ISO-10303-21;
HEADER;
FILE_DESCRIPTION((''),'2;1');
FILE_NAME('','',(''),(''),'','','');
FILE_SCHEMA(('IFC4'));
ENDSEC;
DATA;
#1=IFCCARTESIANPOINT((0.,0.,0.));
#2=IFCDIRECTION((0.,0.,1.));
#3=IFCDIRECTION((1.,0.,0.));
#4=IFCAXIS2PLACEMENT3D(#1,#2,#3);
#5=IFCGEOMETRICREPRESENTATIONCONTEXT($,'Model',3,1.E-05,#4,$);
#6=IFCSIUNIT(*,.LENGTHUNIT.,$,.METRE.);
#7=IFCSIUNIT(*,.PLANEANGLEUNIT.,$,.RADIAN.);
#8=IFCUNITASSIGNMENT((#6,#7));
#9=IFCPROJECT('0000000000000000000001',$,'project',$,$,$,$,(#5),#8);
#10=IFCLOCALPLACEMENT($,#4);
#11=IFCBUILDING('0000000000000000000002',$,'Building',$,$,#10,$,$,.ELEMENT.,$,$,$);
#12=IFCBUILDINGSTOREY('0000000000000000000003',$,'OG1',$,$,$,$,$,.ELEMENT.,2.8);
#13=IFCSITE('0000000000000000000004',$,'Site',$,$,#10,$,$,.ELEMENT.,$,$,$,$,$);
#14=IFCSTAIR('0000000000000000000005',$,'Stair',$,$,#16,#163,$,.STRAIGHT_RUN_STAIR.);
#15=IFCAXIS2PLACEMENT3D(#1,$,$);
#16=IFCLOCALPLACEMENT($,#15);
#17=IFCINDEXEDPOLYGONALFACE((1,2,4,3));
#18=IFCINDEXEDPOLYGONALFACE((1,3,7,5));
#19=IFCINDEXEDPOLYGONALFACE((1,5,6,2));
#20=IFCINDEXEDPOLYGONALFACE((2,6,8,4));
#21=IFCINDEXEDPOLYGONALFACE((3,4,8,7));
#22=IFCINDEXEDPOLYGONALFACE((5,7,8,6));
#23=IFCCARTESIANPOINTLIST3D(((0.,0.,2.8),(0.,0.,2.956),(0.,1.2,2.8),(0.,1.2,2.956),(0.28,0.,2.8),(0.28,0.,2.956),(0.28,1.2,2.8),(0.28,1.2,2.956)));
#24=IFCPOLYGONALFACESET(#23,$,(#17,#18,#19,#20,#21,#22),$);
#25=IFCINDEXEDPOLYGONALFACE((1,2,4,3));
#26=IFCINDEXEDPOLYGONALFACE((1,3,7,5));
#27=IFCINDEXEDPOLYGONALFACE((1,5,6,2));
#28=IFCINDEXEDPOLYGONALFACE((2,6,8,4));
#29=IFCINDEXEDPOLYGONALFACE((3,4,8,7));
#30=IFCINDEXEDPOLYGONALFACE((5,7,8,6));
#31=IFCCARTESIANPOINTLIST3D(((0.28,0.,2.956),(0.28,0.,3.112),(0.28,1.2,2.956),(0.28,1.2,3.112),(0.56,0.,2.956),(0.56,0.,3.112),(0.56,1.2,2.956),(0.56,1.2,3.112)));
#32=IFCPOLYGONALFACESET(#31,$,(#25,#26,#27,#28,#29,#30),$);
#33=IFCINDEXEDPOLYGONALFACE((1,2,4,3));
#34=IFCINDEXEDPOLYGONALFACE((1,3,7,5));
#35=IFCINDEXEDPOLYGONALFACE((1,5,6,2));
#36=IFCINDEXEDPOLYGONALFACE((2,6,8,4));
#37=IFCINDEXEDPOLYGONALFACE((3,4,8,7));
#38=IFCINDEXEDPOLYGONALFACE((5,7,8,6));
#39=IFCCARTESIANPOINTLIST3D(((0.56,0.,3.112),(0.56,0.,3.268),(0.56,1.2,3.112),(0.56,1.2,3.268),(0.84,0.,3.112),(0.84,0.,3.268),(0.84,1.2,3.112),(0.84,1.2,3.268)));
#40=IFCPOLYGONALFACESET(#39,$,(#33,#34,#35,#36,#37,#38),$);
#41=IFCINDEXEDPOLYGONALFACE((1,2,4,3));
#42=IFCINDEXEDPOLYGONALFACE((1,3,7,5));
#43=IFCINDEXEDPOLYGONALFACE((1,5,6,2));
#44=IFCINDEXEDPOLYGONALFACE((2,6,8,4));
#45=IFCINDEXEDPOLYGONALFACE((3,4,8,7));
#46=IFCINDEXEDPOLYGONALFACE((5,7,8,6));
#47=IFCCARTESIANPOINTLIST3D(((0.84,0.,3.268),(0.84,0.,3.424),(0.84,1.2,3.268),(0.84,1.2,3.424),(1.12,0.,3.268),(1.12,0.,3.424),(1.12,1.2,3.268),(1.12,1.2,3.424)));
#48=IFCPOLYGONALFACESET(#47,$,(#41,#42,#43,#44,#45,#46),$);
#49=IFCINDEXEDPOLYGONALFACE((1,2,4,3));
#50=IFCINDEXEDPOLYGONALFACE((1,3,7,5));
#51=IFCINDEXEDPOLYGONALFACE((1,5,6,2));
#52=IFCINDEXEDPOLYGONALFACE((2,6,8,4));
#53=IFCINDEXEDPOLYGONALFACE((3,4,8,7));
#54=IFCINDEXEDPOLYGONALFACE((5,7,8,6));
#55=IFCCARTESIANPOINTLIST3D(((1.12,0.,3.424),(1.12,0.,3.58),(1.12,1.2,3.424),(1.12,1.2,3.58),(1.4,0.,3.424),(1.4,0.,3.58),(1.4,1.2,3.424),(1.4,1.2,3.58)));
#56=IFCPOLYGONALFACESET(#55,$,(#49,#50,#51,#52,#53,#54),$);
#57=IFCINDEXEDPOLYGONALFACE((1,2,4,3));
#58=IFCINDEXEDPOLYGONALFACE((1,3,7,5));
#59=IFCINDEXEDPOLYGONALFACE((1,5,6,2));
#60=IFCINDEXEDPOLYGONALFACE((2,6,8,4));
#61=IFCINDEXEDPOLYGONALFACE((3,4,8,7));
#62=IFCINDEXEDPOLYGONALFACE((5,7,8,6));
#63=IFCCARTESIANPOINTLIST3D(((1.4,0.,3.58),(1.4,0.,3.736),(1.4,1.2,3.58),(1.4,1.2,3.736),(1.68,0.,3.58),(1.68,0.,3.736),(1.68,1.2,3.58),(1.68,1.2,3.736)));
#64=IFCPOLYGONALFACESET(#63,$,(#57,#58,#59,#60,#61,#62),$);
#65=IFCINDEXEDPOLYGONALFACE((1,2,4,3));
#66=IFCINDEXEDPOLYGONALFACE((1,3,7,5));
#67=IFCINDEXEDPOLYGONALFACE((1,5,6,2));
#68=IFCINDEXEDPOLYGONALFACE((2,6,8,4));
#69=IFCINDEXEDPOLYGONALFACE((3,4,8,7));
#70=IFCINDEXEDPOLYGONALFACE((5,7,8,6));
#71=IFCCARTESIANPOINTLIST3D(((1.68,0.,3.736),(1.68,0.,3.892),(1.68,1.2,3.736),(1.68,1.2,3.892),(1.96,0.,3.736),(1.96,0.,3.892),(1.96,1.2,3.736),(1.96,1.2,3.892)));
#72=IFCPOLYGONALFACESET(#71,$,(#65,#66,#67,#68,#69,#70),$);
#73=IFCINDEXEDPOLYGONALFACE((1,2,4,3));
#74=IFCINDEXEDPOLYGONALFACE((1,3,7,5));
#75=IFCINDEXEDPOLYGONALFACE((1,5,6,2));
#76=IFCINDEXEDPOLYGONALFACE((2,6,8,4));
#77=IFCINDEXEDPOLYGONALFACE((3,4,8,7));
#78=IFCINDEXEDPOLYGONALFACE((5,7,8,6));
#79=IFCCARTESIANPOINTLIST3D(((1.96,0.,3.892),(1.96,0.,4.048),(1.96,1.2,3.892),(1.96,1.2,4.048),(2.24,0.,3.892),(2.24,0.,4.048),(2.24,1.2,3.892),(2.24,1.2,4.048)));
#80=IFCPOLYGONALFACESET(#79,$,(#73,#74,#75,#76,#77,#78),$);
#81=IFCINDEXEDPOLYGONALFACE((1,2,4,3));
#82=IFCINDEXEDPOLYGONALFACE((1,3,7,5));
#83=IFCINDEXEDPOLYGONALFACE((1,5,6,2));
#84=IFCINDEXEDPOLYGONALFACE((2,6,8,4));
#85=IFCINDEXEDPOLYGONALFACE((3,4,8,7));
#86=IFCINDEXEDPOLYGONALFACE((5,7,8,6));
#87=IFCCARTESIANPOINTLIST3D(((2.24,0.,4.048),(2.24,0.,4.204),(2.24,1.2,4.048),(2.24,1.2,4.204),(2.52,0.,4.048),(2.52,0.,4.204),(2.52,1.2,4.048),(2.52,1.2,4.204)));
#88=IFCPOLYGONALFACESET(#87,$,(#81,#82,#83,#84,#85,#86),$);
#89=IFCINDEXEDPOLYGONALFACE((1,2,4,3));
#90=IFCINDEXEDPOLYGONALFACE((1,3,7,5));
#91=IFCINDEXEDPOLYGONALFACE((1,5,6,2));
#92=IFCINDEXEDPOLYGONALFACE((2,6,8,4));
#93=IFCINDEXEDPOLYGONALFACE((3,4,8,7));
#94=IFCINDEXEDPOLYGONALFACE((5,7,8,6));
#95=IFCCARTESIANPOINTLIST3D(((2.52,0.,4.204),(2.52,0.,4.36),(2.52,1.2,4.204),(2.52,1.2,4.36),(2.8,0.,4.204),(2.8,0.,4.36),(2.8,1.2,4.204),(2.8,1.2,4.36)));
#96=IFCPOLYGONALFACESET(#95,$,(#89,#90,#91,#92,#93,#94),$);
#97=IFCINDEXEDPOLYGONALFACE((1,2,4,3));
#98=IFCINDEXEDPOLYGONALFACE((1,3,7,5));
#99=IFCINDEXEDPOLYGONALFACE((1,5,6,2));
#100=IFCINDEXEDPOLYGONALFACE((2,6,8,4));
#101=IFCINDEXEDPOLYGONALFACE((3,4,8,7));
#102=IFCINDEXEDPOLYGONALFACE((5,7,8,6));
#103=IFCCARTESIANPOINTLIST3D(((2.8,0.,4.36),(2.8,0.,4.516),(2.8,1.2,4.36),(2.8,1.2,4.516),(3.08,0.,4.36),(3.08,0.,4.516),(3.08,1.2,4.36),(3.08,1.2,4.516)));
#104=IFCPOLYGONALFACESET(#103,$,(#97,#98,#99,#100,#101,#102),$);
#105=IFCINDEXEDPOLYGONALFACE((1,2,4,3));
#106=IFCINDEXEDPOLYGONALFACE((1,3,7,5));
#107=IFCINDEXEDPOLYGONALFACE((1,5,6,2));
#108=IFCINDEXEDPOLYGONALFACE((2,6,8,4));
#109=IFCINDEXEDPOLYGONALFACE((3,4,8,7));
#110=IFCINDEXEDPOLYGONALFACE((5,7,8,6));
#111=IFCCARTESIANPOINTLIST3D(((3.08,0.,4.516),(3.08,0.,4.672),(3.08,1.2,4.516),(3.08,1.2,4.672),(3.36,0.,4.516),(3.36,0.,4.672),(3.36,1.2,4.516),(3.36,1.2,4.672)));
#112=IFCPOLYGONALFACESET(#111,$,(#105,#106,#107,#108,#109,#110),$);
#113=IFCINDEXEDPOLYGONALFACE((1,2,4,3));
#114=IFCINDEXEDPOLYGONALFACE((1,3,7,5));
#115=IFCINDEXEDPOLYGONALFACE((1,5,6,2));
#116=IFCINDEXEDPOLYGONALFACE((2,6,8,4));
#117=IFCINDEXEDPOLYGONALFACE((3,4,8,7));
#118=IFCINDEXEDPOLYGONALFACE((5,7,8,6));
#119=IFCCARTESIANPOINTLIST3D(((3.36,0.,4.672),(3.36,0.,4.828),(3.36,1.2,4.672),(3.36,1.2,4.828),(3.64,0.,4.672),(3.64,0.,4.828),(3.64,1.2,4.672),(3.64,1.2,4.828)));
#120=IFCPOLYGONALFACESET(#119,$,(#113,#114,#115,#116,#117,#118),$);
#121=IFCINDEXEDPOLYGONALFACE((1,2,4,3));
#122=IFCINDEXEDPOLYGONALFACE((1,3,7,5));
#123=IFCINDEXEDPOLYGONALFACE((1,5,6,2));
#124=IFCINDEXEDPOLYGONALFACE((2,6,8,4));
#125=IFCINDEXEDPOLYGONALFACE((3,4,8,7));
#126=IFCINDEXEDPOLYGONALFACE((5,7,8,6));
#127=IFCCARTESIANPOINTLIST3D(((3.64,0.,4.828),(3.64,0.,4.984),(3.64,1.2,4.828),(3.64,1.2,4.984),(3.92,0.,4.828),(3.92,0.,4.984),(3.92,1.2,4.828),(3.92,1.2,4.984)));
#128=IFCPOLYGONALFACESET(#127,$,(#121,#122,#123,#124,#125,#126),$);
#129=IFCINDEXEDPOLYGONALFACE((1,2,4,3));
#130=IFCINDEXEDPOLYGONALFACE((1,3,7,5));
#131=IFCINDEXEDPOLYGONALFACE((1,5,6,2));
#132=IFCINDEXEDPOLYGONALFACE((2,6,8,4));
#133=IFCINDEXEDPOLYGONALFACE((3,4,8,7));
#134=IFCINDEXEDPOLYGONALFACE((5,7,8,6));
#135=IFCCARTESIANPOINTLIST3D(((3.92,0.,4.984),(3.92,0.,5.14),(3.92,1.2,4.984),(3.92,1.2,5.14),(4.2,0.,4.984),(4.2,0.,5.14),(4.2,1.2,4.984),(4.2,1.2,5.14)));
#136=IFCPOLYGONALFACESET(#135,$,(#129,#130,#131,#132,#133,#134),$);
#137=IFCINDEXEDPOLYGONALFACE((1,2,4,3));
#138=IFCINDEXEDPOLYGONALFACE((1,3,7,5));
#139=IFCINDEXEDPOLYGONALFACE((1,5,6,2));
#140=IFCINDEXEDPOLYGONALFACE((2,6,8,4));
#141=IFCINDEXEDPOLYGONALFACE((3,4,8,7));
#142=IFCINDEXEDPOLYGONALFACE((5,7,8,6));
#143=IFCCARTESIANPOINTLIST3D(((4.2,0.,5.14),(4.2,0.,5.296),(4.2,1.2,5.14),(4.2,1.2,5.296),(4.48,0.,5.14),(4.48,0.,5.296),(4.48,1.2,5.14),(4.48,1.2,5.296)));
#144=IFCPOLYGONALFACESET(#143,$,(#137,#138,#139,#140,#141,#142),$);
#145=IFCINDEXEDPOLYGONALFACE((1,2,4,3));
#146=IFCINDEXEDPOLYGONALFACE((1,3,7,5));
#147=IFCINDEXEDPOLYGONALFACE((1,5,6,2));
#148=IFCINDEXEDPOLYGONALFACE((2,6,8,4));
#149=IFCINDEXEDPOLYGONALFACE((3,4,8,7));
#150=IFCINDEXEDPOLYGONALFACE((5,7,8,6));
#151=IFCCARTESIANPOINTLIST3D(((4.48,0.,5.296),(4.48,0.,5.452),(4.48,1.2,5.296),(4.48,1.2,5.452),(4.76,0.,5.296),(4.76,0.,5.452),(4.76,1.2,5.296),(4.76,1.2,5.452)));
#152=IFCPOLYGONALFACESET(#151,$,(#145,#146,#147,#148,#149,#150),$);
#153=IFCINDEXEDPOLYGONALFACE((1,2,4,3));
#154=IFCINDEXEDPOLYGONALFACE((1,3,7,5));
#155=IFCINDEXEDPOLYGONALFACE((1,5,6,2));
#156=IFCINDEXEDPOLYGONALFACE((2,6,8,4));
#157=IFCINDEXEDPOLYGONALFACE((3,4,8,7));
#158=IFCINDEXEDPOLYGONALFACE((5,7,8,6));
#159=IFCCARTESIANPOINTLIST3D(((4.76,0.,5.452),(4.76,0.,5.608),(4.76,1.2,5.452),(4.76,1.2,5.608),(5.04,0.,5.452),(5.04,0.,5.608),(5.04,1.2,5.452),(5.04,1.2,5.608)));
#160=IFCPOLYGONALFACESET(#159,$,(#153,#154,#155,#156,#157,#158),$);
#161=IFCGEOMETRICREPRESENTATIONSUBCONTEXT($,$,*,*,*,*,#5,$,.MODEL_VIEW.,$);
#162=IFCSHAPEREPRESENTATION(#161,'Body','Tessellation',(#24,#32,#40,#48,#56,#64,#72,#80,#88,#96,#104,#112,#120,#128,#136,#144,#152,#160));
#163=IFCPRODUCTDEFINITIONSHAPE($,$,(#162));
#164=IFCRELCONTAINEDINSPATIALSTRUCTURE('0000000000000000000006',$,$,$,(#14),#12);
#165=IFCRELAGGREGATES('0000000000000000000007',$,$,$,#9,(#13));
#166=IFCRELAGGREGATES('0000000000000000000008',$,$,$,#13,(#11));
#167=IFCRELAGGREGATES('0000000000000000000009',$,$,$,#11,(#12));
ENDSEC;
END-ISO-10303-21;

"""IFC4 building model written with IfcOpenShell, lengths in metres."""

from ifc_helpers import new_model, si_unit, frame, frame_2d, origin, origin_with_axes, place, context, subcontext, project, spatial, rectangle, extrude, element, save


model = new_model("IFC4")

# Units and contexts
model_context = context("Model", 3, precision=1e-05, world=origin_with_axes())
sub_context = subcontext(model_context, None, None, "MODEL_VIEW")
ifc_project = project(units=[si_unit("LENGTHUNIT", "METRE"), si_unit("PLANEANGLEUNIT", "RADIAN")], contexts=[model_context])

# Site, building, storey
placement_1 = place(None, origin_with_axes())
site = spatial("IfcSite", under=ifc_project, at=placement_1, Name="Site", CompositionType="ELEMENT")
building = spatial("IfcBuilding", under=site, at=placement_1, Name="Building", CompositionType="ELEMENT")
storey = spatial("IfcBuildingStorey", under=building, Name="OG1", CompositionType="ELEMENT", Elevation=2.8)

# Stair
placement_2 = place(None, origin_with_axes())
placement_3 = place(placement_2, frame((0.0, 0.0, 2.8)))
stair_placement = place(placement_3, origin())
element("IfcStair", 1, at=stair_placement, inside=storey, Name="Stair", PredefinedType="STRAIGHT_RUN_STAIR", context=sub_context, shape_type="SolidModel", body=[
    extrude(rectangle(XDim=0.28, YDim=1.2, at=frame_2d((0.14, 0.6))), origin(), (0.0, 0.0, 1.0), 0.156),
    extrude(rectangle(XDim=0.28, YDim=1.2, at=frame_2d((0.14, 0.6))), frame((0.28, 0.0, 0.156)), (0.0, 0.0, 1.0), 0.156),
    extrude(rectangle(XDim=0.28, YDim=1.2, at=frame_2d((0.14, 0.6))), frame((0.56, 0.0, 0.312)), (0.0, 0.0, 1.0), 0.156),
    extrude(rectangle(XDim=0.28, YDim=1.2, at=frame_2d((0.14, 0.6))), frame((0.84, 0.0, 0.468)), (0.0, 0.0, 1.0), 0.156),
    extrude(rectangle(XDim=0.28, YDim=1.2, at=frame_2d((0.14, 0.6))), frame((1.12, 0.0, 0.624)), (0.0, 0.0, 1.0), 0.156),
    extrude(rectangle(XDim=0.28, YDim=1.2, at=frame_2d((0.14, 0.6))), frame((1.4, 0.0, 0.78)), (0.0, 0.0, 1.0), 0.156),
    extrude(rectangle(XDim=0.28, YDim=1.2, at=frame_2d((0.14, 0.6))), frame((1.68, 0.0, 0.936)), (0.0, 0.0, 1.0), 0.156),
    extrude(rectangle(XDim=0.28, YDim=1.2, at=frame_2d((0.14, 0.6))), frame((1.96, 0.0, 1.092)), (0.0, 0.0, 1.0), 0.156),
    extrude(rectangle(XDim=0.28, YDim=1.2, at=frame_2d((0.14, 0.6))), frame((2.24, 0.0, 1.248)), (0.0, 0.0, 1.0), 0.156),
    extrude(rectangle(XDim=0.28, YDim=1.2, at=frame_2d((0.14, 0.6))), frame((2.52, 0.0, 1.404)), (0.0, 0.0, 1.0), 0.156),
    extrude(rectangle(XDim=0.28, YDim=1.2, at=frame_2d((0.14, 0.6))), frame((2.8, 0.0, 1.56)), (0.0, 0.0, 1.0), 0.156),
    extrude(rectangle(XDim=0.28, YDim=1.2, at=frame_2d((0.14, 0.6))), frame((3.08, 0.0, 1.716)), (0.0, 0.0, 1.0), 0.156),
    extrude(rectangle(XDim=0.28, YDim=1.2, at=frame_2d((0.14, 0.6))), frame((3.36, 0.0, 1.872)), (0.0, 0.0, 1.0), 0.156),
    extrude(rectangle(XDim=0.28, YDim=1.2, at=frame_2d((0.14, 0.6))), frame((3.64, 0.0, 2.028)), (0.0, 0.0, 1.0), 0.156),
    extrude(rectangle(XDim=0.28, YDim=1.2, at=frame_2d((0.14, 0.6))), frame((3.92, 0.0, 2.184)), (0.0, 0.0, 1.0), 0.156),
    extrude(rectangle(XDim=0.28, YDim=1.2, at=frame_2d((0.14, 0.6))), frame((4.2, 0.0, 2.34)), (0.0, 0.0, 1.0), 0.156),
    extrude(rectangle(XDim=0.28, YDim=1.2, at=frame_2d((0.14, 0.6))), frame((4.48, 0.0, 2.496)), (0.0, 0.0, 1.0), 0.156),
    extrude(rectangle(XDim=0.28, YDim=1.2, at=frame_2d((0.14, 0.6))), frame((4.76, 0.0, 2.652)), (0.0, 0.0, 1.0), 0.156),
])

save(model, "model.ifc")
